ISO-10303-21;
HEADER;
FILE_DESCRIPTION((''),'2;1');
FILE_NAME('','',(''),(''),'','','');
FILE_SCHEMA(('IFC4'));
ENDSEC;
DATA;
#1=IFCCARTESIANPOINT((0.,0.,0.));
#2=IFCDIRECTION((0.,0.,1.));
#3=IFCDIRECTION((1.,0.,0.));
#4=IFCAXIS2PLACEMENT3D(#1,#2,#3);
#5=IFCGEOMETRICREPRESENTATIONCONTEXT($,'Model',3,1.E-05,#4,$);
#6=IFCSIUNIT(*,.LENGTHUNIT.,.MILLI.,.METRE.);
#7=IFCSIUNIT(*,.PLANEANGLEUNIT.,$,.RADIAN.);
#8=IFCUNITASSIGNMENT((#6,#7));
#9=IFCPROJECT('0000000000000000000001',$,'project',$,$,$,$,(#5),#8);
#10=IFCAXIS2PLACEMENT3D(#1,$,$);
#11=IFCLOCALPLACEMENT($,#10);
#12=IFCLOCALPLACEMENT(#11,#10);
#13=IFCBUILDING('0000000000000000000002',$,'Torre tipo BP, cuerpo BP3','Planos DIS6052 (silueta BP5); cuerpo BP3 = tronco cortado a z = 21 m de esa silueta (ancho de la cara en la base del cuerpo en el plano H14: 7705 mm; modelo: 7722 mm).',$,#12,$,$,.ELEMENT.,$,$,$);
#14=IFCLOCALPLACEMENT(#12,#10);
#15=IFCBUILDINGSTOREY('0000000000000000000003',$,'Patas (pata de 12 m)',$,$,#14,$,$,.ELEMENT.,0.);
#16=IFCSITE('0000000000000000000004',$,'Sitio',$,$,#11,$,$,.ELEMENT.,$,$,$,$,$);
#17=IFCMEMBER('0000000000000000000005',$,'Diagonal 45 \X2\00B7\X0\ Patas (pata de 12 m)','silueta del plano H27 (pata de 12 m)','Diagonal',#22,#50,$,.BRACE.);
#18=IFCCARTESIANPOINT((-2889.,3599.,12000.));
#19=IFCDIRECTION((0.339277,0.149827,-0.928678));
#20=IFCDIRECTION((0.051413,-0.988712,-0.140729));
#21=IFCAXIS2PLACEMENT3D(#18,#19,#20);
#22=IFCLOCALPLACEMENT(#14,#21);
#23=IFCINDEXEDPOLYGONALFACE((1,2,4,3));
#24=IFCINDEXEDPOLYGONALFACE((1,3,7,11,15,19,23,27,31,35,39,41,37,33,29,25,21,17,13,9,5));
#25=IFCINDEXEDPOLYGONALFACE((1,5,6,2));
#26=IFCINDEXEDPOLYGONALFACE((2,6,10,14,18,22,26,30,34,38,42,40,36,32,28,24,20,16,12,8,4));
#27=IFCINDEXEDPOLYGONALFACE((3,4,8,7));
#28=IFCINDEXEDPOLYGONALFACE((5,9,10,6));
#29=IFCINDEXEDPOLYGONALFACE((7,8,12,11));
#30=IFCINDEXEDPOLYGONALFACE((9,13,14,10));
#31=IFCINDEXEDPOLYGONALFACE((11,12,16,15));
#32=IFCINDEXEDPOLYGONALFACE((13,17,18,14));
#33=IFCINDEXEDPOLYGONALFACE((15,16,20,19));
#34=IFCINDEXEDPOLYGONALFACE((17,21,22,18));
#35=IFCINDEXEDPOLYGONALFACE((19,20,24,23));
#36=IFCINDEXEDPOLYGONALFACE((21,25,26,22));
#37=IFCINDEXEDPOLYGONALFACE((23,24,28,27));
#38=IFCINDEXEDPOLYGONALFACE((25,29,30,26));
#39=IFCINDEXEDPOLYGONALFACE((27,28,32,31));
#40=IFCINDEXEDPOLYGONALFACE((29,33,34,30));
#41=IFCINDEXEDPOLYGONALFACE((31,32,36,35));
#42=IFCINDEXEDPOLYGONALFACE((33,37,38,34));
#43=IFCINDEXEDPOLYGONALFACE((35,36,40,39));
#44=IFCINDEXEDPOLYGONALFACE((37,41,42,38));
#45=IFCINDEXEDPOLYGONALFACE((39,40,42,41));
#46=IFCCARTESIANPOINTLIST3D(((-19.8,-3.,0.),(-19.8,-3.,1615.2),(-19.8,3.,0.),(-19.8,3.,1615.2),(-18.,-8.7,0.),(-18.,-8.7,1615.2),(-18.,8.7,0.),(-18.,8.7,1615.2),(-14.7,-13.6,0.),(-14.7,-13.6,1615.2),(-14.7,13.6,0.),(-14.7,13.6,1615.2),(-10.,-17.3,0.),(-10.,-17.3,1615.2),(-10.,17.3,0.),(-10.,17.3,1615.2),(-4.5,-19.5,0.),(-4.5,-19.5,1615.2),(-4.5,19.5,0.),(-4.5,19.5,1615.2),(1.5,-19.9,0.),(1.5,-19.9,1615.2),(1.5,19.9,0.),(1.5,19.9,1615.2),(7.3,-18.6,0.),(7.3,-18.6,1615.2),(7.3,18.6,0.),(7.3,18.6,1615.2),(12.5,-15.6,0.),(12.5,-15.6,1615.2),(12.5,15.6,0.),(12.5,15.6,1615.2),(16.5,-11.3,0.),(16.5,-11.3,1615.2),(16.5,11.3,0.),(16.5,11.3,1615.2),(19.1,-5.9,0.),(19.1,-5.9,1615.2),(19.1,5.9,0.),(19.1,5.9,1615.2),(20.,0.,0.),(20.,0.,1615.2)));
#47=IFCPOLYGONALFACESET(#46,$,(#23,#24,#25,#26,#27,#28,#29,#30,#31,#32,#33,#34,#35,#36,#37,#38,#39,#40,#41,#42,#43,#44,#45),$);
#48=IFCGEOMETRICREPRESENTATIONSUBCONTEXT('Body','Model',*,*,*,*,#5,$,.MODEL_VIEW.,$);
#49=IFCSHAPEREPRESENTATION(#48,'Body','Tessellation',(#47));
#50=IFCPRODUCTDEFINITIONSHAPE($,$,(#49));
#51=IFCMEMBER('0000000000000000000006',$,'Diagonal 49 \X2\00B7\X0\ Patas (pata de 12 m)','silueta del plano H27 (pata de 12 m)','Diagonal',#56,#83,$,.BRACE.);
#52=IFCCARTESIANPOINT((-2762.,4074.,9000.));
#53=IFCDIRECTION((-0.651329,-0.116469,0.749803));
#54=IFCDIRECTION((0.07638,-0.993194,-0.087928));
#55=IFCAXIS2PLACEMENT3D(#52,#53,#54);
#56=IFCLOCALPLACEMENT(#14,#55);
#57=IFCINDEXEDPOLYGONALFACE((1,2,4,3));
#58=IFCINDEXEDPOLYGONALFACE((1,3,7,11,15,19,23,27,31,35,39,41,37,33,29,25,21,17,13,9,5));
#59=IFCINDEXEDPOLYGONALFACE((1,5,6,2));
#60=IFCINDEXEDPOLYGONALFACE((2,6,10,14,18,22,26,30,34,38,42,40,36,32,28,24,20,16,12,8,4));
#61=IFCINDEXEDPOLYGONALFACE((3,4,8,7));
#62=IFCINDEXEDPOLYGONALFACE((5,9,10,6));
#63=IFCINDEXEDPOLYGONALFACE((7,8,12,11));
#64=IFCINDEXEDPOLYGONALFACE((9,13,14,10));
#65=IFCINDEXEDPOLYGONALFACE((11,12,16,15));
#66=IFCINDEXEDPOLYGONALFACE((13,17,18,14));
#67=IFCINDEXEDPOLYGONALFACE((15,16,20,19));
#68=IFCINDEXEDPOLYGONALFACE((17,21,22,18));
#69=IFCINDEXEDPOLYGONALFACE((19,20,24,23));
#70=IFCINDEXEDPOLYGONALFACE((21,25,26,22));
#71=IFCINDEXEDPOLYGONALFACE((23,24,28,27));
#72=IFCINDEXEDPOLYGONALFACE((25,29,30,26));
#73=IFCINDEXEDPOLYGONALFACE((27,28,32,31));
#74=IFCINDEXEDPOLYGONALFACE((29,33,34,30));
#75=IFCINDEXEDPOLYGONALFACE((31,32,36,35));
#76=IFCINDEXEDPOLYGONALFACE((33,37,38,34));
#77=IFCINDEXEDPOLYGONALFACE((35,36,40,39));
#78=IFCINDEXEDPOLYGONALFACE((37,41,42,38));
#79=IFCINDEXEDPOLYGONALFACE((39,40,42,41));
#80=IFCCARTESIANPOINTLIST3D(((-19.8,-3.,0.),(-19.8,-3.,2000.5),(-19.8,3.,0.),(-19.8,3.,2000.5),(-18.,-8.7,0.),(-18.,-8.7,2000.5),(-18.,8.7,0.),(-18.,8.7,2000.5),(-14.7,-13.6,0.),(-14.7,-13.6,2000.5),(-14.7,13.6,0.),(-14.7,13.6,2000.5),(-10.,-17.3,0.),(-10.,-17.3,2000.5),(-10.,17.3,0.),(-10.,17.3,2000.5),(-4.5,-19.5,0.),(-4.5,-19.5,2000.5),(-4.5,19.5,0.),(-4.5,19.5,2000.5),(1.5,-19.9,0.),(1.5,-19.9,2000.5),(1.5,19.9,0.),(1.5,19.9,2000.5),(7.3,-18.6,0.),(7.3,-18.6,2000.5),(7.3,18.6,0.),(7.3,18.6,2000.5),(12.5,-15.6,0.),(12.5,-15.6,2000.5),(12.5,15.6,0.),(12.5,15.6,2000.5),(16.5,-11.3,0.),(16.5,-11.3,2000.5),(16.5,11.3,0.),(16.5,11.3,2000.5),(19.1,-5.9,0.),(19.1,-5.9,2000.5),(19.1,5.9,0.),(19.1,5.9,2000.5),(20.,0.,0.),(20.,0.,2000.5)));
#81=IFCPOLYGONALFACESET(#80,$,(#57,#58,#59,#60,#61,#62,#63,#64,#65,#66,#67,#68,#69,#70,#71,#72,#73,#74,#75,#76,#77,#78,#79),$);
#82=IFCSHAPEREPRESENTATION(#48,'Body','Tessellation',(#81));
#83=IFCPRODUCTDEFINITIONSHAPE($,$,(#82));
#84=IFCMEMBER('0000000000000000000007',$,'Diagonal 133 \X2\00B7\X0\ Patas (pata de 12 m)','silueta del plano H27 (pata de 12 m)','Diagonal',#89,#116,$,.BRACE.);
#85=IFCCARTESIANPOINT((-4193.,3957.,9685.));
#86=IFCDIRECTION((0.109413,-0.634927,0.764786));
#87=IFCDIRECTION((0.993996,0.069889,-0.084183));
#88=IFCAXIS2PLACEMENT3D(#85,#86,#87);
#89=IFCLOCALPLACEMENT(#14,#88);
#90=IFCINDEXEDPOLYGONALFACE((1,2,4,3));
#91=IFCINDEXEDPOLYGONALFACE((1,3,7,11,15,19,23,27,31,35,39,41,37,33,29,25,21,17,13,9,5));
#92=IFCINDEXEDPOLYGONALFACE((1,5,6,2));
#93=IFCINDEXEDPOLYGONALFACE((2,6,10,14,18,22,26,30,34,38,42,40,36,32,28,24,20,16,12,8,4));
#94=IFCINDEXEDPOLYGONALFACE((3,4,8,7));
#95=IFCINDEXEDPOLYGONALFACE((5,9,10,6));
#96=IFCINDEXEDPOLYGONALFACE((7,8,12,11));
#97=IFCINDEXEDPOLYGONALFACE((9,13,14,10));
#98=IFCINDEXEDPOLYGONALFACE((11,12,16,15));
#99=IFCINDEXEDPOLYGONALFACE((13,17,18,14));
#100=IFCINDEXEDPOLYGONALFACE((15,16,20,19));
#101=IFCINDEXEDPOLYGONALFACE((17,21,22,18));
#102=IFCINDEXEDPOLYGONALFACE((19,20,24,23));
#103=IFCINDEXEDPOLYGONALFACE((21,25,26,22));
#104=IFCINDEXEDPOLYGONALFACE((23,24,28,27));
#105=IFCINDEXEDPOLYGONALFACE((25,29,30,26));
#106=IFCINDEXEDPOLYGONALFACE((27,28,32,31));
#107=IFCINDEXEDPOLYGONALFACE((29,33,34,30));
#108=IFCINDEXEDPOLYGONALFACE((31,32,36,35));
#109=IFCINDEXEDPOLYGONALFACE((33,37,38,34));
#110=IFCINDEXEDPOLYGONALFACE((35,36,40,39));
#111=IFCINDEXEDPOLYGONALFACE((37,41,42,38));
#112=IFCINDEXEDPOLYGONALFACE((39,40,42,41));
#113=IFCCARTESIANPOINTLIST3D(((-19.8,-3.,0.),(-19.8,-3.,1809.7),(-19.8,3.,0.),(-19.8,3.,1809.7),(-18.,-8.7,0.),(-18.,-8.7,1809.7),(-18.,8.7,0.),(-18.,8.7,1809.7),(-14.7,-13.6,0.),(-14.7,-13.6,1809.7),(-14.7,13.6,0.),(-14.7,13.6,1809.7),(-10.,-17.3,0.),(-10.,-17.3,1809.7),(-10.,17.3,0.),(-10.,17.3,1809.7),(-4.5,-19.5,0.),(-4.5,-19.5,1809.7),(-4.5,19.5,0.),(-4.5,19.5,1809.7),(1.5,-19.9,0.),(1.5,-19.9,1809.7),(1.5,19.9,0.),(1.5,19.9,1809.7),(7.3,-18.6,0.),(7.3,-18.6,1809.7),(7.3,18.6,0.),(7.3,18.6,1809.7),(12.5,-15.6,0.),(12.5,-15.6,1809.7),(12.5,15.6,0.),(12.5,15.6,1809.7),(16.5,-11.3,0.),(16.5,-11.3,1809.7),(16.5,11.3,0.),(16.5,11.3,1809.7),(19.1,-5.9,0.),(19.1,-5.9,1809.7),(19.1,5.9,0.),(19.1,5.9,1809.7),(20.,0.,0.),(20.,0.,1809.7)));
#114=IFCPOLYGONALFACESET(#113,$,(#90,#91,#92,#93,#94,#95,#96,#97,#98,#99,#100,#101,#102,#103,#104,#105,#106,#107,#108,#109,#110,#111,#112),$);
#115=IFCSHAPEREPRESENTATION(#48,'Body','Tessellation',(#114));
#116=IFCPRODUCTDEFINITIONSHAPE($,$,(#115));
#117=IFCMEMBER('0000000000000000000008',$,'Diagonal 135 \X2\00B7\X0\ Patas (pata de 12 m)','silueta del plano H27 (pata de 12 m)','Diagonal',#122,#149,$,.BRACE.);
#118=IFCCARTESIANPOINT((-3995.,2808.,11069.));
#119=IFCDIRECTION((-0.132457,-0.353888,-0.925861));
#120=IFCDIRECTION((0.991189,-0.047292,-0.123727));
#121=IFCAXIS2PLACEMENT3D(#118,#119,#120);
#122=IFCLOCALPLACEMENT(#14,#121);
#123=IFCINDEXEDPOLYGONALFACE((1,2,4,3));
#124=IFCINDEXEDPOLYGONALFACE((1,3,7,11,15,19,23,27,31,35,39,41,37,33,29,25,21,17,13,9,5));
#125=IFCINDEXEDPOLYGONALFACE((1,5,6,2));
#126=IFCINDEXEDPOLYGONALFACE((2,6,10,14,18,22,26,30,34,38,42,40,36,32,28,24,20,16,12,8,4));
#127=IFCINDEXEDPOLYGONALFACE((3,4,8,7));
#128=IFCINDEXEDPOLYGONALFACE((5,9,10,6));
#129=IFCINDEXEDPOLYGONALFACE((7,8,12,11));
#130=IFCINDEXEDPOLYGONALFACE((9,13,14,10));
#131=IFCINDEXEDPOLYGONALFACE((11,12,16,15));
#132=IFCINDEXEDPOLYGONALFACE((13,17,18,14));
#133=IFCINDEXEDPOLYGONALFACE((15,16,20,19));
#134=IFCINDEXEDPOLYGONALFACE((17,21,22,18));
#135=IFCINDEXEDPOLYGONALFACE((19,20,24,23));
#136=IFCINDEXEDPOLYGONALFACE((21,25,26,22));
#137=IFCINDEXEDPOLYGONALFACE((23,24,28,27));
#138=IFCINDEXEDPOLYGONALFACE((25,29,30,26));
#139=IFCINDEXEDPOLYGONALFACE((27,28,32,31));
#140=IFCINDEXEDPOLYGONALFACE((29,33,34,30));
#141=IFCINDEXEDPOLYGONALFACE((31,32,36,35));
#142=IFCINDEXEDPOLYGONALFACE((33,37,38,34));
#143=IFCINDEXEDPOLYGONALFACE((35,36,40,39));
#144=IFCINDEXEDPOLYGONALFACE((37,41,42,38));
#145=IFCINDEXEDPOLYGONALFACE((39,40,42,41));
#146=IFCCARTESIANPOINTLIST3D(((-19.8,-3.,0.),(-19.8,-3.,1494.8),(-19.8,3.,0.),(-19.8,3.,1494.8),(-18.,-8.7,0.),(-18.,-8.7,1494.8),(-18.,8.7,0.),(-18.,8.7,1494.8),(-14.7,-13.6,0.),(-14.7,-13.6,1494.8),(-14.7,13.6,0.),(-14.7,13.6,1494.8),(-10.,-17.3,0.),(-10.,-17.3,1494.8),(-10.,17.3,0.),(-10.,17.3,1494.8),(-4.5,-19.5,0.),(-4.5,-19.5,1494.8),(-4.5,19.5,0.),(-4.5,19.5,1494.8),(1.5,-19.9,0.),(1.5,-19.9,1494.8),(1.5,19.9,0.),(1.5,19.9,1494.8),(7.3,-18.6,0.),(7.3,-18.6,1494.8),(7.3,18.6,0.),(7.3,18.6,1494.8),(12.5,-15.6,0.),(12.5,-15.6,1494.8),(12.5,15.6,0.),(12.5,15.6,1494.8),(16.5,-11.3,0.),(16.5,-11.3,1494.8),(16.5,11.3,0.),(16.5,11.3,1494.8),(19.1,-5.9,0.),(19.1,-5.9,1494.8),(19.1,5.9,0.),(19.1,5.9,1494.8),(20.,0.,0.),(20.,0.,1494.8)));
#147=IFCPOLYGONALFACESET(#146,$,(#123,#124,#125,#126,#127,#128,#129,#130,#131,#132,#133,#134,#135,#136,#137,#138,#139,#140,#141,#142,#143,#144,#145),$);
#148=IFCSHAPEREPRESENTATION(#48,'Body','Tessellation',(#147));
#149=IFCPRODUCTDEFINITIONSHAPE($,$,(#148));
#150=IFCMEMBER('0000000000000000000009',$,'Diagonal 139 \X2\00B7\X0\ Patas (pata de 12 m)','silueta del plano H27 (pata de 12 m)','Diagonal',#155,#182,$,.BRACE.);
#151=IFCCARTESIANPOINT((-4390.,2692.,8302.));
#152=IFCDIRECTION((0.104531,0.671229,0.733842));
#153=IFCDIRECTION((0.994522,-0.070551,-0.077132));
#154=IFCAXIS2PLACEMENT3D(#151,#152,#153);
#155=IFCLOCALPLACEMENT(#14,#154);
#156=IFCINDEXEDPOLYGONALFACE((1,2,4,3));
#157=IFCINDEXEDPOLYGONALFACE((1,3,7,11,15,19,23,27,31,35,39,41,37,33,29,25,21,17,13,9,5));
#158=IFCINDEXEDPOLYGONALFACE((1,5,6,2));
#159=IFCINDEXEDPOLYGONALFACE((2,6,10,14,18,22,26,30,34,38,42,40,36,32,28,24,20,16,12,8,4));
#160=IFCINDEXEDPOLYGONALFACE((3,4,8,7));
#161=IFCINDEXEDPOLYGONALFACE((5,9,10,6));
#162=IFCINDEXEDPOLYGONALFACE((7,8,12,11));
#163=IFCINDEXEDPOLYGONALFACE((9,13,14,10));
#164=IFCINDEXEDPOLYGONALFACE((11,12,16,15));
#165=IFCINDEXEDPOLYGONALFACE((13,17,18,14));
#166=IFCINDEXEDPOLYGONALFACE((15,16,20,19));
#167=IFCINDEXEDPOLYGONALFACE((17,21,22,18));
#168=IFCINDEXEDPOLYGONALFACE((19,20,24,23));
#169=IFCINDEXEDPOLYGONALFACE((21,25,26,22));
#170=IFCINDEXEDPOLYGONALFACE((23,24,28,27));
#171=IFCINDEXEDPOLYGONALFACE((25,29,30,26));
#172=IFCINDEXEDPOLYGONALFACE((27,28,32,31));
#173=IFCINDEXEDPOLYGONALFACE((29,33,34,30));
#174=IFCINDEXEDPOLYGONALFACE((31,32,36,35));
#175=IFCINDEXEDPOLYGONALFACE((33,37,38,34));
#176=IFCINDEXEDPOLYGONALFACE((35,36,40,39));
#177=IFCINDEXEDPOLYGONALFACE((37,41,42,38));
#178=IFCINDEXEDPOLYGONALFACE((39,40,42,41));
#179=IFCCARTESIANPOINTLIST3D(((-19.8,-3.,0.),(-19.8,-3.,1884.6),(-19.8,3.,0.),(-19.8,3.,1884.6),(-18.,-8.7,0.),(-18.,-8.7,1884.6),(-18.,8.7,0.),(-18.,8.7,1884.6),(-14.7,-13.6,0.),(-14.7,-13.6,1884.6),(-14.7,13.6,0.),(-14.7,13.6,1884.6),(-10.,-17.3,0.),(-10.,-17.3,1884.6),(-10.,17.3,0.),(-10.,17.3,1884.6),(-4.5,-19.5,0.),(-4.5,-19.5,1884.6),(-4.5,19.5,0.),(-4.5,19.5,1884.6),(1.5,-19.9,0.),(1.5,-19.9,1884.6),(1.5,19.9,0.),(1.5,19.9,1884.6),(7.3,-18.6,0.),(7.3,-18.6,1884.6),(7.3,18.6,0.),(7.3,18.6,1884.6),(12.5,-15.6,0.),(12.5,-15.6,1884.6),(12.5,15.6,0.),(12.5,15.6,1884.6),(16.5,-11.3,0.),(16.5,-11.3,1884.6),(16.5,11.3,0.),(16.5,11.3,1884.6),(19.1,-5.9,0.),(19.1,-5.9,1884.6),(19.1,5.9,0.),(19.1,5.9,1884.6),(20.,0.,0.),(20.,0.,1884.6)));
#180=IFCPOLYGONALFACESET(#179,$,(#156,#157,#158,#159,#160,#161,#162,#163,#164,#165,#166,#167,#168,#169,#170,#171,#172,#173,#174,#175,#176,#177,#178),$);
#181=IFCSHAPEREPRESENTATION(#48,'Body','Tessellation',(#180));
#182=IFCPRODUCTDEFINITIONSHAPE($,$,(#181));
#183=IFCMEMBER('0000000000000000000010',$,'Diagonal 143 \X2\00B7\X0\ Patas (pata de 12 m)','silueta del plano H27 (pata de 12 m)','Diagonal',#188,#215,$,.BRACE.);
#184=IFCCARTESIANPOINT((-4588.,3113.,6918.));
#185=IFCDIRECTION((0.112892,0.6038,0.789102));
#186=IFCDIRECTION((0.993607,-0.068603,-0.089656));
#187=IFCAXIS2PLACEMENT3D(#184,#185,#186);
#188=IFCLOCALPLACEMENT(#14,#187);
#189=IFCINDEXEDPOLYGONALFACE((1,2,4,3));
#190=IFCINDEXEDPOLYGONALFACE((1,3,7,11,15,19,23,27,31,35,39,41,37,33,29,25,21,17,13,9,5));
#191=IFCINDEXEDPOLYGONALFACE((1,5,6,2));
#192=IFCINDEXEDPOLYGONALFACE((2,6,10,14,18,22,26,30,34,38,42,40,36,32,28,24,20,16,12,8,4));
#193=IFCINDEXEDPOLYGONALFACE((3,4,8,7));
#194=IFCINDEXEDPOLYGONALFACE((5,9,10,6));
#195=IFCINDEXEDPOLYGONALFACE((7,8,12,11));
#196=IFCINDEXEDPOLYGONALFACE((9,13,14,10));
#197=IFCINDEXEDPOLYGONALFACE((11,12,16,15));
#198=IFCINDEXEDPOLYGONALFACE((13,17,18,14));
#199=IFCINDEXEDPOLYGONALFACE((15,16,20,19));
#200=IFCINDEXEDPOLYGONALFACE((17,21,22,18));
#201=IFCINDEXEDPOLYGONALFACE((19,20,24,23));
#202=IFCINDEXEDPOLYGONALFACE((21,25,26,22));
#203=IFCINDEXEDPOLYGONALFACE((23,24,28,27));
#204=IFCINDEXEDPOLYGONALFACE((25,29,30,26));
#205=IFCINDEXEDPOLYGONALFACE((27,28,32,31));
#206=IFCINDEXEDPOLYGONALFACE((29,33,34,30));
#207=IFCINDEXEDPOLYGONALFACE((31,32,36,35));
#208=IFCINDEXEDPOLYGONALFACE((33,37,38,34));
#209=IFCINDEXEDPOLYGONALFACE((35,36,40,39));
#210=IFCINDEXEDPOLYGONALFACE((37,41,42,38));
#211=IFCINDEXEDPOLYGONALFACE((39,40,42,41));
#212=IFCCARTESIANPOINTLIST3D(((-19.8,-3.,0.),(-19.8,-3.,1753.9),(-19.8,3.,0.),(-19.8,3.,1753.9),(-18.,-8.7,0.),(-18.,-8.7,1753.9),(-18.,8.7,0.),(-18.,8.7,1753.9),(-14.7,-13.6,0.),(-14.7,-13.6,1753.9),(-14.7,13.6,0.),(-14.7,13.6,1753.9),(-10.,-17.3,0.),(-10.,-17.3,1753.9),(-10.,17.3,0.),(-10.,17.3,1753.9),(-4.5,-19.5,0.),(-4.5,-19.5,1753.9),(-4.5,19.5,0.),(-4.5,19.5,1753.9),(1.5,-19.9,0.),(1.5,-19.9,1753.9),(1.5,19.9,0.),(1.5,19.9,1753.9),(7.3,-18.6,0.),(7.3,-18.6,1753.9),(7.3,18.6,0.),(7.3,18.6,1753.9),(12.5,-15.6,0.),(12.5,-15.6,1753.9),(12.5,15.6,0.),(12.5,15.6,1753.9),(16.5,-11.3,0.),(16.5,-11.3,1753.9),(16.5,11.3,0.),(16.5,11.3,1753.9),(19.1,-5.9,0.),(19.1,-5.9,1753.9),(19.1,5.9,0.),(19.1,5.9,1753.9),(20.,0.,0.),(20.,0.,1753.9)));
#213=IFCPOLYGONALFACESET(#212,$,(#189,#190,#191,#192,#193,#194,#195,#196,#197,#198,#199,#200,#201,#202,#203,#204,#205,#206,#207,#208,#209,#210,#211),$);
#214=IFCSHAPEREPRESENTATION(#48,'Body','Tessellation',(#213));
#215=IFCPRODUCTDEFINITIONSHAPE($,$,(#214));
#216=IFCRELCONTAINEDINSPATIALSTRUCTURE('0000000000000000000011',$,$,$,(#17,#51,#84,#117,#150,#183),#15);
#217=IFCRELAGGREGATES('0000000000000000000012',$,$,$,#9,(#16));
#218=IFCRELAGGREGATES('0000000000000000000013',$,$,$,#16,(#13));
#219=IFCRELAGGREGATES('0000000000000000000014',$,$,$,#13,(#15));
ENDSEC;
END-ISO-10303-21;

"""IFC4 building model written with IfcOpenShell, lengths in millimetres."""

from ifc_helpers import new_model, si_unit, frame, origin, origin_with_axes, place, context, subcontext, project, spatial, circle, extrude, element, save


model = new_model("IFC4")

# Units and contexts
model_context = context("Model", 3, precision=1e-05, world=origin_with_axes())
body_context = subcontext(model_context, "Body", "Model", "MODEL_VIEW")
ifc_project = project(units=[si_unit("LENGTHUNIT", "METRE", prefix="MILLI"), si_unit("PLANEANGLEUNIT", "RADIAN")], contexts=[model_context])

# Site, building, storey
site_placement = place(None, origin())
site = spatial("IfcSite", under=ifc_project, at=site_placement, Name="Sitio", CompositionType="ELEMENT")
building_placement = place(site_placement, origin())
building = spatial("IfcBuilding", under=site, at=building_placement, Name="Torre tipo BP, cuerpo BP3", Description="Planos DIS6052 (silueta BP5); cuerpo BP3 = tronco cortado a z = 21 m de esa silueta (ancho de la cara en la base del cuerpo en el plano H14: 7705 mm; modelo: 7722 mm).", CompositionType="ELEMENT")
storey_placement = place(building_placement, origin())
storey = spatial("IfcBuildingStorey", under=building, at=storey_placement, Name="Patas (pata de 12 m)", CompositionType="ELEMENT", Elevation=0.0)

# Members
member_1_placement = place(storey_placement, frame((-2889.0, 3599.0, 12000.0), z_axis=(0.339277, 0.149827, -0.928678), x_axis=(0.051413, -0.988712, -0.140729)))
element("IfcMember", 1, at=member_1_placement, inside=storey, Name="Diagonal 45 · Patas (pata de 12 m)", Description="silueta del plano H27 (pata de 12 m)", ObjectType="Diagonal", PredefinedType="BRACE", context=body_context, shape_type="SweptSolid", body=[
    extrude(circle(Radius=20.0), None, (0.0, 0.0, 1.0), 1615.2),
])
member_2_placement = place(storey_placement, frame((-2762.0, 4074.0, 9000.0), z_axis=(-0.651329, -0.116469, 0.749803), x_axis=(0.07638, -0.993194, -0.087928)))
element("IfcMember", 2, at=member_2_placement, inside=storey, Name="Diagonal 49 · Patas (pata de 12 m)", Description="silueta del plano H27 (pata de 12 m)", ObjectType="Diagonal", PredefinedType="BRACE", context=body_context, shape_type="SweptSolid", body=[
    extrude(circle(Radius=20.0), None, (0.0, 0.0, 1.0), 2000.5),
])
member_3_placement = place(storey_placement, frame((-4193.0, 3957.0, 9685.0), z_axis=(0.109413, -0.634927, 0.764786), x_axis=(0.993996, 0.069889, -0.084183)))
element("IfcMember", 3, at=member_3_placement, inside=storey, Name="Diagonal 133 · Patas (pata de 12 m)", Description="silueta del plano H27 (pata de 12 m)", ObjectType="Diagonal", PredefinedType="BRACE", context=body_context, shape_type="SweptSolid", body=[
    extrude(circle(Radius=20.0), None, (0.0, 0.0, 1.0), 1809.7),
])
member_4_placement = place(storey_placement, frame((-3995.0, 2808.0, 11069.0), z_axis=(-0.132457, -0.353888, -0.925861), x_axis=(0.991189, -0.047292, -0.123727)))
element("IfcMember", 4, at=member_4_placement, inside=storey, Name="Diagonal 135 · Patas (pata de 12 m)", Description="silueta del plano H27 (pata de 12 m)", ObjectType="Diagonal", PredefinedType="BRACE", context=body_context, shape_type="SweptSolid", body=[
    extrude(circle(Radius=20.0), None, (0.0, 0.0, 1.0), 1494.8),
])
member_5_placement = place(storey_placement, frame((-4390.0, 2692.0, 8302.0), z_axis=(0.104531, 0.671229, 0.733842), x_axis=(0.994522, -0.070551, -0.077132)))
element("IfcMember", 5, at=member_5_placement, inside=storey, Name="Diagonal 139 · Patas (pata de 12 m)", Description="silueta del plano H27 (pata de 12 m)", ObjectType="Diagonal", PredefinedType="BRACE", context=body_context, shape_type="SweptSolid", body=[
    extrude(circle(Radius=20.0), None, (0.0, 0.0, 1.0), 1884.6),
])
member_6_placement = place(storey_placement, frame((-4588.0, 3113.0, 6918.0), z_axis=(0.112892, 0.6038, 0.789102), x_axis=(0.993607, -0.068603, -0.089656)))
element("IfcMember", 6, at=member_6_placement, inside=storey, Name="Diagonal 143 · Patas (pata de 12 m)", Description="silueta del plano H27 (pata de 12 m)", ObjectType="Diagonal", PredefinedType="BRACE", context=body_context, shape_type="SweptSolid", body=[
    extrude(circle(Radius=20.0), None, (0.0, 0.0, 1.0), 1753.9),
])

save(model, "model.ifc")
